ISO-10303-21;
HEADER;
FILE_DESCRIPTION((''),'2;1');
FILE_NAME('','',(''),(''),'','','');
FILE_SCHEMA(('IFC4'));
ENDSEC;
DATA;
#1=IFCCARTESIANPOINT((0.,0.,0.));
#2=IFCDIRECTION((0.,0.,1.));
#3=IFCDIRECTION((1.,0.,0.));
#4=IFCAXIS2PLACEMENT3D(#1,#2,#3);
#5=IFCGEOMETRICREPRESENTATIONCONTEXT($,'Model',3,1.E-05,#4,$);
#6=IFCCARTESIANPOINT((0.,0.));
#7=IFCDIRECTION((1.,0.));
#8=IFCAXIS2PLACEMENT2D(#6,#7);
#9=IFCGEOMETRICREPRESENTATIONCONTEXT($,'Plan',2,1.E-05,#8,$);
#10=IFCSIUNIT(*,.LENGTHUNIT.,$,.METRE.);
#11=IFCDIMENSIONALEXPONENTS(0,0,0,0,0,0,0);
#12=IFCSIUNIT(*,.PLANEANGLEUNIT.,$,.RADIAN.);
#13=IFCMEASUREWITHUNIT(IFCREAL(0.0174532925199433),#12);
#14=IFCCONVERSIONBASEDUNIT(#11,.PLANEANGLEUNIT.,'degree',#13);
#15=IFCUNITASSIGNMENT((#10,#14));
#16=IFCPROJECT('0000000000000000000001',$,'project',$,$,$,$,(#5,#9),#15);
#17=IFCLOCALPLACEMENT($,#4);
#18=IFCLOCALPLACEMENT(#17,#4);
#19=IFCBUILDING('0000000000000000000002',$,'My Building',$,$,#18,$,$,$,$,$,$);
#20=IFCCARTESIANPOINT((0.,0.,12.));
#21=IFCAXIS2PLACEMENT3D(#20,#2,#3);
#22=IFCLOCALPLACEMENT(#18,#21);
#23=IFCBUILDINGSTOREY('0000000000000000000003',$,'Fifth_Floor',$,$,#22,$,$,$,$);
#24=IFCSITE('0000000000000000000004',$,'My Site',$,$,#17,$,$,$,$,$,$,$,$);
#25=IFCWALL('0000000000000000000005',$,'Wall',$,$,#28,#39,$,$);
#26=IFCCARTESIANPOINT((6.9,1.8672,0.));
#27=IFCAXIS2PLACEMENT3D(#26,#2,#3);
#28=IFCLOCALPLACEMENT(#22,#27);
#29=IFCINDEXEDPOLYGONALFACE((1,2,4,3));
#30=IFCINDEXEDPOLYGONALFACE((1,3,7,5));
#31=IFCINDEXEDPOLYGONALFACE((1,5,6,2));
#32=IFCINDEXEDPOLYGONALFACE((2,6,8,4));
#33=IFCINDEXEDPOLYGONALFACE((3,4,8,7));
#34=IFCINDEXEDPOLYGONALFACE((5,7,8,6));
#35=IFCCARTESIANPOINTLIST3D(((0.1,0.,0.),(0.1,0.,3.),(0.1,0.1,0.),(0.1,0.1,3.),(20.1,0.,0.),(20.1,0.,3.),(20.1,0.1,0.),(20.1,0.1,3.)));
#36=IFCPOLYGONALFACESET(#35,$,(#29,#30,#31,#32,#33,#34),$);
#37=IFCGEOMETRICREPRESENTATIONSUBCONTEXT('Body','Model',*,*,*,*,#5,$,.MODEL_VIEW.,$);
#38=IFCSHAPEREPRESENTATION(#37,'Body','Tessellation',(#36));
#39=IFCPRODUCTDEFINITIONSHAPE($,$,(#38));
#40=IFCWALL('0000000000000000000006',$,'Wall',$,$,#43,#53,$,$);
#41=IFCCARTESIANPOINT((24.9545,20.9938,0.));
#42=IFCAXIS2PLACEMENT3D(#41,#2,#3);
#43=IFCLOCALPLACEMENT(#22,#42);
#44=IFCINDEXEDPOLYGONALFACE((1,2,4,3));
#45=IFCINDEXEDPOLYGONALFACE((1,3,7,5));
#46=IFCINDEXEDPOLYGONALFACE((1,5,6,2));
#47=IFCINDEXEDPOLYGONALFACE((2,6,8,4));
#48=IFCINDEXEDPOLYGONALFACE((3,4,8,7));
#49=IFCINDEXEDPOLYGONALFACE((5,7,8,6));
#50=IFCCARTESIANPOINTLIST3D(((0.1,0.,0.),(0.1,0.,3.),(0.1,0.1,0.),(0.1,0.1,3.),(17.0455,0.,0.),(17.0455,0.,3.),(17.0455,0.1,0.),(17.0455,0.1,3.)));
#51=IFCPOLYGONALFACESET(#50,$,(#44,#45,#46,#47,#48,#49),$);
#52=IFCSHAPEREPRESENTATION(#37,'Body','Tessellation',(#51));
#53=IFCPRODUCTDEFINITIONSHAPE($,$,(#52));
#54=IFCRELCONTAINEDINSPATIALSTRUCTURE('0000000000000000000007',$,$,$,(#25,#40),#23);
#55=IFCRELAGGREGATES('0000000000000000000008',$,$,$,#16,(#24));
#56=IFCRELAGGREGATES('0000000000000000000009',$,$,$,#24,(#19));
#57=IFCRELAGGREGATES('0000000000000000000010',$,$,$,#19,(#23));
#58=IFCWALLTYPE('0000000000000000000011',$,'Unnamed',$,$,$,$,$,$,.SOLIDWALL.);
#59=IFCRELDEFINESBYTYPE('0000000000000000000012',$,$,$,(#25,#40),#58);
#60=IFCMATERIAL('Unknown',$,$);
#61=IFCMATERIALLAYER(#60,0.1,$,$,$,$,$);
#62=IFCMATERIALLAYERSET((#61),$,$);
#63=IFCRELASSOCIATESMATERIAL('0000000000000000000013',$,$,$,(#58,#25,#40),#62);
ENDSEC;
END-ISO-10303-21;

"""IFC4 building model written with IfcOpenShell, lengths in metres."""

from ifc_helpers import new_model, entity, si_unit, converted_unit, frame, origin_with_axes, origin_2d_with_axis, place, context, subcontext, project, spatial, line, indexed_curve, outline, extrude, material, layer, layer_set, layer_usage, type_object, element, save


model = new_model("IFC4")

# Units and contexts
model_context = context("Model", 3, precision=1e-05, world=origin_with_axes())
plan_context = context("Plan", 2, precision=1e-05, world=origin_2d_with_axis())
body_context = subcontext(model_context, "Body", "Model", "MODEL_VIEW")
ifc_project = project(units=[si_unit("LENGTHUNIT", "METRE"), converted_unit("PLANEANGLEUNIT", "degree", entity("IfcReal", 0.0174532925199433), si_unit("PLANEANGLEUNIT", "RADIAN"), dimensions=[0, 0, 0, 0, 0, 0, 0])], contexts=[model_context, plan_context])

# Site, building, storey
site_placement = place(None, origin_with_axes())
site = spatial("IfcSite", under=ifc_project, at=site_placement, Name="My Site")
building_placement = place(site_placement, origin_with_axes())
building = spatial("IfcBuilding", under=site, at=building_placement, Name="My Building")
storey_placement = place(building_placement, frame((0.0, 0.0, 12.0), z_axis=(0.0, 0.0, 1.0), x_axis=(1.0, 0.0, 0.0)))
storey = spatial("IfcBuildingStorey", under=building, at=storey_placement, Name="Fifth_Floor")

# Shared definitions
ifc_material = material(Name="Unknown")

# Walls
ifc_layer_1 = layer(ifc_material, 0.1)
ifc_layer_set_1 = layer_set([ifc_layer_1])
wall_type = type_object("IfcWallType", Name="Unnamed", PredefinedType="SOLIDWALL", material=ifc_layer_set_1)
ifc_layer_usage_1 = layer_usage(ifc_layer_set_1, "AXIS2", "POSITIVE", 0.0)
wall_1_placement = place(storey_placement, frame((6.9, 1.8672, 0.0), z_axis=(0.0, 0.0, 1.0), x_axis=(1.0, 0.0, 0.0)))
element("IfcWall", 1, at=wall_1_placement, inside=storey, type_object=wall_type, material=ifc_layer_usage_1, Name="Wall", context=body_context, shape_type="SweptSolid", body=[
    extrude(outline(indexed_curve([(0.1, 0.0), (0.1, 0.1), (20.1, 0.1), (20.1, 0.0)], segments=[line(1, 2, 3, 4, 1)])), origin_with_axes(), (0.0, 0.0, 1.0), 3.0),
])
ifc_layer_usage_2 = layer_usage(ifc_layer_set_1, "AXIS2", "POSITIVE", 0.0)
wall_2_placement = place(storey_placement, frame((24.9545, 20.9938, 0.0), z_axis=(0.0, 0.0, 1.0), x_axis=(1.0, 0.0, 0.0)))
element("IfcWall", 2, at=wall_2_placement, inside=storey, type_object=wall_type, material=ifc_layer_usage_2, Name="Wall", context=body_context, shape_type="SweptSolid", body=[
    extrude(outline(indexed_curve([(0.1, 0.0), (0.1, 0.1), (17.0455, 0.1), (17.0455, 0.0)], segments=[line(1, 2, 3, 4, 1)])), origin_with_axes(), (0.0, 0.0, 1.0), 3.0),
])

save(model, "model.ifc")
